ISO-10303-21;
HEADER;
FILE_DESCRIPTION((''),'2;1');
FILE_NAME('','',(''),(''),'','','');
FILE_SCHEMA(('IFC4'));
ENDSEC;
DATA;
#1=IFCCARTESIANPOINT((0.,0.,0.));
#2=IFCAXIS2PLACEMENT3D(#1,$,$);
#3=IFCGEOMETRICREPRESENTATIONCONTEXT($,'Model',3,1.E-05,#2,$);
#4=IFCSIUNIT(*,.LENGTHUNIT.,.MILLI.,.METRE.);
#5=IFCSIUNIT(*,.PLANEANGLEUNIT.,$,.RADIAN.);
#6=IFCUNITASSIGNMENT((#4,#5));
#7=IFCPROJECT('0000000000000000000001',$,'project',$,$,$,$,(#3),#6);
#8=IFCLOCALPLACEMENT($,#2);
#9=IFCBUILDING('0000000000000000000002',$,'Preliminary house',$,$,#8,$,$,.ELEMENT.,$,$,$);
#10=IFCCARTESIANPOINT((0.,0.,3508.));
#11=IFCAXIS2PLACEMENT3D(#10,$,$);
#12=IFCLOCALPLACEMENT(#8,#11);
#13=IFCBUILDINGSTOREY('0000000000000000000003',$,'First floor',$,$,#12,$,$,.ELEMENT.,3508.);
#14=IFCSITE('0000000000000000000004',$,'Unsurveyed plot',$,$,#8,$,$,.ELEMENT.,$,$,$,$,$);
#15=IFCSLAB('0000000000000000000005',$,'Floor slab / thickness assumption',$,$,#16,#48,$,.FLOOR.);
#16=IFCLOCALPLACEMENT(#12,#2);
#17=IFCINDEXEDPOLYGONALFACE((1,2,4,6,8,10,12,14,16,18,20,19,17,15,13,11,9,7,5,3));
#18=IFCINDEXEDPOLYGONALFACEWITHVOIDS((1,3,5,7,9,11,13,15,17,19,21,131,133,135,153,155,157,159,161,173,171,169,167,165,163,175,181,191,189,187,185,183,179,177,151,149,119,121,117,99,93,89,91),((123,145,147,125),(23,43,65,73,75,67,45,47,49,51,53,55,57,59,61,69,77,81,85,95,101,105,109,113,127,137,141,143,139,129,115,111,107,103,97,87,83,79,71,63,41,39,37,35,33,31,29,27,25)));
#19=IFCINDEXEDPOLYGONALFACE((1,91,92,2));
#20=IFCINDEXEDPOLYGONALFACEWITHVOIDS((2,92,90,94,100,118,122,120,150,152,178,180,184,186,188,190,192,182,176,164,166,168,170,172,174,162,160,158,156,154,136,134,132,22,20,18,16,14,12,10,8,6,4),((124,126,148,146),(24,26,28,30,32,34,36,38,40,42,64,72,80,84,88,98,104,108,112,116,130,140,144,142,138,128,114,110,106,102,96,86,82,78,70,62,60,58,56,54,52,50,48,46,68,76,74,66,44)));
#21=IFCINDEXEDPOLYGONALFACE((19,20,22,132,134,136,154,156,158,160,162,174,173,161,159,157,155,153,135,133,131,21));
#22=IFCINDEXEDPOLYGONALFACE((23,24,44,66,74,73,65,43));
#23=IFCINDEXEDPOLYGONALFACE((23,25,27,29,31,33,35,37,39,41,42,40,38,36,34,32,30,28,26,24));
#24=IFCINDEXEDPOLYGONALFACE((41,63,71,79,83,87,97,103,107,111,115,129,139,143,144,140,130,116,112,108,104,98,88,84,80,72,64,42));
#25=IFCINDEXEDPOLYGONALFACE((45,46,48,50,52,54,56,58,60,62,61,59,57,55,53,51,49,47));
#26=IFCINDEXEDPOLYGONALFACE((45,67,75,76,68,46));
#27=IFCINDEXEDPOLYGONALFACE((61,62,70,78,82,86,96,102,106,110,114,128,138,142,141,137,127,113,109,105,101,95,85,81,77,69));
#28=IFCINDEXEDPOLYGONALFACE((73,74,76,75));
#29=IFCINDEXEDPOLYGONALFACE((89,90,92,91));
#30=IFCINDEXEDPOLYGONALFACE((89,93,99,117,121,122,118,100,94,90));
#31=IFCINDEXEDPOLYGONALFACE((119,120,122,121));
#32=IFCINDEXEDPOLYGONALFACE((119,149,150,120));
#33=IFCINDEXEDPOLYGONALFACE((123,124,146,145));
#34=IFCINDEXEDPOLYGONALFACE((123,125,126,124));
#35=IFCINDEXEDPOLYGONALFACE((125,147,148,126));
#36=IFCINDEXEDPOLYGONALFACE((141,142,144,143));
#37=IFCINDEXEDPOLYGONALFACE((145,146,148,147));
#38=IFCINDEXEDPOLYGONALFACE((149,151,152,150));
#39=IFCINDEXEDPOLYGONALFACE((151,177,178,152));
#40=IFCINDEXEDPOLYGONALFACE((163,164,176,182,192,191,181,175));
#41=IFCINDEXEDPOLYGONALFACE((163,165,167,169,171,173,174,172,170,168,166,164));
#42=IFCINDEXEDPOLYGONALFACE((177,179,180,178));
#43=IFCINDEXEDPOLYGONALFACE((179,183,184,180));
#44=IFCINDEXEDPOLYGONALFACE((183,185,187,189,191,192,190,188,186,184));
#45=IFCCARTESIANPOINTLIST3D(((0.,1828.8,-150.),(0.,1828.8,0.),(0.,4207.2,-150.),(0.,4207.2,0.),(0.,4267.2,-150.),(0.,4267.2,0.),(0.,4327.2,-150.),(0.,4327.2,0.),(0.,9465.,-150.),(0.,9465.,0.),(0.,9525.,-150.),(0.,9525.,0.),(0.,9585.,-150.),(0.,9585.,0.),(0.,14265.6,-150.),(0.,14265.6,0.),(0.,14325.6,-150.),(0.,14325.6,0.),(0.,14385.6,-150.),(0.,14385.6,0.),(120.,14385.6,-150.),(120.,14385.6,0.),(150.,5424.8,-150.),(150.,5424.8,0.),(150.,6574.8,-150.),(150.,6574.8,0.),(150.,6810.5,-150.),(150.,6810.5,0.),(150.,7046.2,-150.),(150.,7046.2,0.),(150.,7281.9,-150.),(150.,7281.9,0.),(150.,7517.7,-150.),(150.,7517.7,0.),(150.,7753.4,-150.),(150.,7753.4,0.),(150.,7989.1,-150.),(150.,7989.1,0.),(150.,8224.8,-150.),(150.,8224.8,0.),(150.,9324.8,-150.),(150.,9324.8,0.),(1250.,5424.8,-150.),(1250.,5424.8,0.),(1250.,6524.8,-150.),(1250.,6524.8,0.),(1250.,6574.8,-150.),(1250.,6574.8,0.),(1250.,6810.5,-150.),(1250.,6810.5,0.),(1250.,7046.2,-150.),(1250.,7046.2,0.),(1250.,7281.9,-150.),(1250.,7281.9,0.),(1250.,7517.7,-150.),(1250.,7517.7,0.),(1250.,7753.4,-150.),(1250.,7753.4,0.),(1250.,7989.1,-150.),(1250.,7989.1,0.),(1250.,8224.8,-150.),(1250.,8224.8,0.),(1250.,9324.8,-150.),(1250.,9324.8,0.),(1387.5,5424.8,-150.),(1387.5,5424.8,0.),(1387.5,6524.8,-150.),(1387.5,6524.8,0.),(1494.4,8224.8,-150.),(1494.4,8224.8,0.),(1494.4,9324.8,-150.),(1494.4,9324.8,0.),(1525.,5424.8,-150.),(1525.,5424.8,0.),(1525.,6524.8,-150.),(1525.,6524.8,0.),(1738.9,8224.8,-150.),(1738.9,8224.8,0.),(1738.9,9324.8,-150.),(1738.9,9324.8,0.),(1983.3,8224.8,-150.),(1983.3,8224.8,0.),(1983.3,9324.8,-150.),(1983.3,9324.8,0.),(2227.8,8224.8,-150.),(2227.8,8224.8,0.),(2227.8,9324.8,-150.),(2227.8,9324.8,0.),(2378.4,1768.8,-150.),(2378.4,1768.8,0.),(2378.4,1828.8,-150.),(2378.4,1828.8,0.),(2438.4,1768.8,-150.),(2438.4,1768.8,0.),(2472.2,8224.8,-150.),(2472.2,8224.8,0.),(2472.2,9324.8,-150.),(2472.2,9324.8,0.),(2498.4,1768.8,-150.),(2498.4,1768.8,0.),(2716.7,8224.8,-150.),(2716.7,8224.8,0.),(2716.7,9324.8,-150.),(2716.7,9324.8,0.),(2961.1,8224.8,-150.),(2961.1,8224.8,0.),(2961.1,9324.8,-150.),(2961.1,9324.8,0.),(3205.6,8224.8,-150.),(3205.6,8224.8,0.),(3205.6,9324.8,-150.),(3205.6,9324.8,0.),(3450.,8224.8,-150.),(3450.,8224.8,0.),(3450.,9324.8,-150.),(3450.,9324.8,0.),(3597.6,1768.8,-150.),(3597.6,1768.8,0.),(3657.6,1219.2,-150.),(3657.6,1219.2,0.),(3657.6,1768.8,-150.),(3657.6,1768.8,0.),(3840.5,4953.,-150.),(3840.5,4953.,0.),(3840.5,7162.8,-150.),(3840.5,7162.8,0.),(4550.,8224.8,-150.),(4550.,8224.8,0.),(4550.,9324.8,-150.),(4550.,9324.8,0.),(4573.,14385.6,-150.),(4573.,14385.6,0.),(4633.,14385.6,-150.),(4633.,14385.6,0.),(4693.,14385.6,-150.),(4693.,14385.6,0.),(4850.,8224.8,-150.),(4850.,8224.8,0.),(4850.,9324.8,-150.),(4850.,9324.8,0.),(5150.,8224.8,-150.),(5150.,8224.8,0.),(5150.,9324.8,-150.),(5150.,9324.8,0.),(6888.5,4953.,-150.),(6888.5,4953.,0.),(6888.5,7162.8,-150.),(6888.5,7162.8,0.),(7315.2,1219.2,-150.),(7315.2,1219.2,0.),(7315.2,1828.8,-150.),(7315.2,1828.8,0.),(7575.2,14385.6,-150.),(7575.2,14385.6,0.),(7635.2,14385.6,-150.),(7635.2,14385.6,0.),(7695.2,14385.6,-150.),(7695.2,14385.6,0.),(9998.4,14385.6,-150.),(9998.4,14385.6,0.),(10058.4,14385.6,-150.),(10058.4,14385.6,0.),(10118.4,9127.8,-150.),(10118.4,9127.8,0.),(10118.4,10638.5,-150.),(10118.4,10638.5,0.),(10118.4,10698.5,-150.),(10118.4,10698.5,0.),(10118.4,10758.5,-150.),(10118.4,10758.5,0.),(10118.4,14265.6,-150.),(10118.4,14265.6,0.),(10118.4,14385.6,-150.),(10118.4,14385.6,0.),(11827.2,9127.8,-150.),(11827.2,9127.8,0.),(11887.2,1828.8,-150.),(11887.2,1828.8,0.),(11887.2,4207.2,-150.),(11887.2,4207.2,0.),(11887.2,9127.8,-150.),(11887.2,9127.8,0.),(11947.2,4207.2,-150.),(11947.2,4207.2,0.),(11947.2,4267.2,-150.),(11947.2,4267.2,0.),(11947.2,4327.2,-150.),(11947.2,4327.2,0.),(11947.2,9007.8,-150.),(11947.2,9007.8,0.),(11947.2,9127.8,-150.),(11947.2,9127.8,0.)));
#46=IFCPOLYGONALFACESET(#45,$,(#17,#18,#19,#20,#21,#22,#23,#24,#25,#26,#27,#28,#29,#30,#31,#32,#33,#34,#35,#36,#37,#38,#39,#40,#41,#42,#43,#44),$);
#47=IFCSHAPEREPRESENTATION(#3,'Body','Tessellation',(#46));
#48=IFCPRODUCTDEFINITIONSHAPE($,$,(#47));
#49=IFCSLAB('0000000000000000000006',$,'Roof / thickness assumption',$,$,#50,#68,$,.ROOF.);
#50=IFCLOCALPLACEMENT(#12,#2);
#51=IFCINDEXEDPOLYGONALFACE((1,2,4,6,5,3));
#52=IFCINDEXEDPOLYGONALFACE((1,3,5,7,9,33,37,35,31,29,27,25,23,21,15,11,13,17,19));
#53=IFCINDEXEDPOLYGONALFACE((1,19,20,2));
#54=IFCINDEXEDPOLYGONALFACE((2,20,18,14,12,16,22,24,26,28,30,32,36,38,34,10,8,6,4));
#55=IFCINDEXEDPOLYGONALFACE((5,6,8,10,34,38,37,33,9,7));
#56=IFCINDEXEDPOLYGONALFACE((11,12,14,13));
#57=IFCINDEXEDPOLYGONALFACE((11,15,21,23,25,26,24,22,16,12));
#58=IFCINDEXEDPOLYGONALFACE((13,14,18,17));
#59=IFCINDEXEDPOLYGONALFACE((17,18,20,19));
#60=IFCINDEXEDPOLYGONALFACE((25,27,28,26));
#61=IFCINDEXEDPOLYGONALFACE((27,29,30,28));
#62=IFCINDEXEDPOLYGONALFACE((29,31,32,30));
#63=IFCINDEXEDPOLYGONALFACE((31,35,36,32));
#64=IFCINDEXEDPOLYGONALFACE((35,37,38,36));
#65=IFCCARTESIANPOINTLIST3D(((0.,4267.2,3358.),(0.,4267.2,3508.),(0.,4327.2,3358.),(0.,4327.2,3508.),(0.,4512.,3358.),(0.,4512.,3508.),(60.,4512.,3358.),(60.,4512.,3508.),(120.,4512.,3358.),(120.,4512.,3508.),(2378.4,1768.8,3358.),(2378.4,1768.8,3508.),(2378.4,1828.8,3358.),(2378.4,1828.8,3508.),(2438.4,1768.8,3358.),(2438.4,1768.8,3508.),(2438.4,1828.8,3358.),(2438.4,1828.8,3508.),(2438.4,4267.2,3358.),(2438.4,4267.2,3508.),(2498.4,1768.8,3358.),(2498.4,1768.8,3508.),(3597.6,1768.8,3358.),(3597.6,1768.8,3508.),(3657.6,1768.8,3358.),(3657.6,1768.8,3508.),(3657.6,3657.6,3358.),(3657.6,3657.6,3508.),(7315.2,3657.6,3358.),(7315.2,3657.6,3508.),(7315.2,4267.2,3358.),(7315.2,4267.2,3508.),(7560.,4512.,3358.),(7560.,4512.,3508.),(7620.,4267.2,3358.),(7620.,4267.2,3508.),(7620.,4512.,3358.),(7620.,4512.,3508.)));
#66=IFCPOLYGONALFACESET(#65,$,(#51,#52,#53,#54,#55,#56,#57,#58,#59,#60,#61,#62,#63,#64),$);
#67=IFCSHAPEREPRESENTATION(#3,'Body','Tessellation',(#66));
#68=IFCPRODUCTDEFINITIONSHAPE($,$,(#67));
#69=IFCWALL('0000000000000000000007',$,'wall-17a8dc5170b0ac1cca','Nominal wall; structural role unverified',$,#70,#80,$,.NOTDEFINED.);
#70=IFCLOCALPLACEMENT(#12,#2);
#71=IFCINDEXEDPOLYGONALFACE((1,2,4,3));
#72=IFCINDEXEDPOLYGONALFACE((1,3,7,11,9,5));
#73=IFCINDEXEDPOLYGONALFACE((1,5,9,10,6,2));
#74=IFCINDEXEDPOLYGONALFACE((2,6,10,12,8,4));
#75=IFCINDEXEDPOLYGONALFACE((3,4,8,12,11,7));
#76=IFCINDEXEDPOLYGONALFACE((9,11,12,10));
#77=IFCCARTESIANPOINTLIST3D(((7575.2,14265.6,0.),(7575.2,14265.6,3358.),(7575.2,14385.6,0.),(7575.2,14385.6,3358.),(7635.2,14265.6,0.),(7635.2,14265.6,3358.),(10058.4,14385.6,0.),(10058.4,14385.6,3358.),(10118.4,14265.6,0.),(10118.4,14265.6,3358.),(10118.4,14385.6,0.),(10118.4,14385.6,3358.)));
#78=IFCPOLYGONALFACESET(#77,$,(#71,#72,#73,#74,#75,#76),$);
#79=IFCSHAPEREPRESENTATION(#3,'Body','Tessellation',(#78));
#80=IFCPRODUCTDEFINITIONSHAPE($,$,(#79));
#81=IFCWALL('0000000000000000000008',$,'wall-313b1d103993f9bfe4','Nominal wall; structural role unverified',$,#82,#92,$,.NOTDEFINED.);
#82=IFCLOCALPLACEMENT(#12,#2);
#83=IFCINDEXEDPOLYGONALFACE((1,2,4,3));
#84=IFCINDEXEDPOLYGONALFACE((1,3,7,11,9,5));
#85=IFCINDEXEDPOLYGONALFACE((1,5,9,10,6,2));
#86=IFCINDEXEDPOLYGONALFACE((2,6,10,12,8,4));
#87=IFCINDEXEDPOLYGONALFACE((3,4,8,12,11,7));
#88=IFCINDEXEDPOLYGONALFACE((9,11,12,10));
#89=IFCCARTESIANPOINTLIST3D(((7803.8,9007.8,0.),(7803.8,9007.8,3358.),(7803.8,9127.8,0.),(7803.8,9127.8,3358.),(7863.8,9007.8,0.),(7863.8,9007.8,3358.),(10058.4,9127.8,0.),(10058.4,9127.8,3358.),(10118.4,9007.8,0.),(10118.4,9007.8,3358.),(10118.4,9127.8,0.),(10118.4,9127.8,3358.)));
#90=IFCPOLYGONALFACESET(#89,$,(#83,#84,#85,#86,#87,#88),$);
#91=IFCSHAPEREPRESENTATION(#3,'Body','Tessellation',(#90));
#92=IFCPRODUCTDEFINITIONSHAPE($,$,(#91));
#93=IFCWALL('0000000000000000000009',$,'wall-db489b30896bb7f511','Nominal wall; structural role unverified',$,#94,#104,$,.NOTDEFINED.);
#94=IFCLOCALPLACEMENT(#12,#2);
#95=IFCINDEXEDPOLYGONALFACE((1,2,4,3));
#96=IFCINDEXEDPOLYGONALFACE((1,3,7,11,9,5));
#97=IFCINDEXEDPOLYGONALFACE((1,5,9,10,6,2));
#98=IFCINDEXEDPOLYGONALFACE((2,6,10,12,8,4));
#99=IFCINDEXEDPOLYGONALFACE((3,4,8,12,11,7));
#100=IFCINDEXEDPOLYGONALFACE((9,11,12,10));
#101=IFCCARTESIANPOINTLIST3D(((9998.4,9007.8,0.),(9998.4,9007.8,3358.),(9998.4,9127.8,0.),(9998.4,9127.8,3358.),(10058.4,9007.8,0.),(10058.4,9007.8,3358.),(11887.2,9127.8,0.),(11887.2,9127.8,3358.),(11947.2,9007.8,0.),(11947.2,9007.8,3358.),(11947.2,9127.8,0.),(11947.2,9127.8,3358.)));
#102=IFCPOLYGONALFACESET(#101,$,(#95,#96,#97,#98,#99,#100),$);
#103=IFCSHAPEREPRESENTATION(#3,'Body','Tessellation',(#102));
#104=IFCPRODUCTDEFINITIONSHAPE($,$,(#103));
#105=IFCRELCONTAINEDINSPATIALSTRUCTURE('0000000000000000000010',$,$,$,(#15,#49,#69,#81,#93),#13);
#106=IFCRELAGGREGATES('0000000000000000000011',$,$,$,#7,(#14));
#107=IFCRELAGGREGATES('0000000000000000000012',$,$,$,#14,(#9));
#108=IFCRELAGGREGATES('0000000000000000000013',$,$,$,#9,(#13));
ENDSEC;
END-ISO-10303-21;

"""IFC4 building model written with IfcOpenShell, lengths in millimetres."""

from ifc_helpers import new_model, si_unit, frame, origin, place, context, project, spatial, polyline, outline, extrude, element, save


model = new_model("IFC4")

# Units and contexts
model_context = context("Model", 3, precision=1e-05, world=origin())
ifc_project = project(units=[si_unit("LENGTHUNIT", "METRE", prefix="MILLI"), si_unit("PLANEANGLEUNIT", "RADIAN")], contexts=[model_context])

# Site, building, storey
placement_1 = place(None, origin())
site = spatial("IfcSite", under=ifc_project, at=placement_1, Name="Unsurveyed plot", CompositionType="ELEMENT")
building = spatial("IfcBuilding", under=site, at=placement_1, Name="Preliminary house", CompositionType="ELEMENT")
placement_2 = place(placement_1, frame((0.0, 0.0, 3508.0)))
storey = spatial("IfcBuildingStorey", under=building, at=placement_2, Name="First floor", CompositionType="ELEMENT", Elevation=3508.0)

# Slabs
element("IfcSlab", 1, at=placement_2, inside=storey, Name="Floor slab / thickness assumption", PredefinedType="FLOOR", context=model_context, shape_type="SweptSolid", body=[
    extrude(outline(polyline([(2378.4, 1828.8), (0.0, 1828.8), (0.0, 4207.2), (0.0, 4267.2), (0.0, 4327.2), (0.0, 9465.0), (0.0, 9525.0), (0.0, 9585.0), (0.0, 14265.6), (0.0, 14325.6), (0.0, 14385.6), (120.0, 14385.6), (4573.0, 14385.6), (4633.0, 14385.6), (4693.0, 14385.6), (7575.2, 14385.6), (7635.2, 14385.6), (7695.2, 14385.6), (9998.4, 14385.6), (10058.4, 14385.6), (10118.4, 14385.6), (10118.4, 14265.6), (10118.4, 10758.5), (10118.4, 10698.5), (10118.4, 10638.5), (10118.4, 9127.8), (11827.2, 9127.8), (11887.2, 9127.8), (11947.2, 9127.8), (11947.2, 9007.8), (11947.2, 4327.2), (11947.2, 4267.2), (11947.2, 4207.2), (11887.2, 4207.2), (11887.2, 1828.8), (7315.2, 1828.8), (7315.2, 1219.2), (3657.6, 1219.2), (3657.6, 1768.8), (3597.6, 1768.8), (2498.4, 1768.8), (2438.4, 1768.8), (2378.4, 1768.8), (2378.4, 1828.8)]), holes=[polyline([(1387.5, 6524.8), (1250.0, 6524.8), (1250.0, 6574.8), (1250.0, 6810.5), (1250.0, 7046.2), (1250.0, 7281.9), (1250.0, 7517.7), (1250.0, 7753.4), (1250.0, 7989.1), (1250.0, 8224.8), (1494.4, 8224.8), (1738.9, 8224.8), (1983.3, 8224.8), (2227.8, 8224.8), (2472.2, 8224.8), (2716.7, 8224.8), (2961.1, 8224.8), (3205.6, 8224.8), (3450.0, 8224.8), (4550.0, 8224.8), (4850.0, 8224.8), (5150.0, 8224.8), (5150.0, 9324.8), (4850.0, 9324.8), (4550.0, 9324.8), (3450.0, 9324.8), (3205.6, 9324.8), (2961.1, 9324.8), (2716.7, 9324.8), (2472.2, 9324.8), (2227.8, 9324.8), (1983.3, 9324.8), (1738.9, 9324.8), (1494.4, 9324.8), (1250.0, 9324.8), (150.0, 9324.8), (150.0, 8224.8), (150.0, 7989.1), (150.0, 7753.4), (150.0, 7517.7), (150.0, 7281.9), (150.0, 7046.2), (150.0, 6810.5), (150.0, 6574.8), (150.0, 5424.8), (1250.0, 5424.8), (1387.5, 5424.8), (1525.0, 5424.8), (1525.0, 6524.8), (1387.5, 6524.8)]), polyline([(6888.5, 7162.8), (3840.5, 7162.8), (3840.5, 4953.0), (6888.5, 4953.0), (6888.5, 7162.8)])]), frame((0.0, 0.0, -150.0)), (0.0, 0.0, 1.0), 150.0),
])
element("IfcSlab", 2, at=placement_2, inside=storey, Name="Roof / thickness assumption", PredefinedType="ROOF", context=model_context, shape_type="SweptSolid", body=[
    extrude(outline(polyline([(0.0, 4512.0), (60.0, 4512.0), (120.0, 4512.0), (7560.0, 4512.0), (7620.0, 4512.0), (7620.0, 4267.2), (7315.2, 4267.2), (7315.2, 3657.6), (3657.6, 3657.6), (3657.6, 1768.8), (3597.6, 1768.8), (2498.4, 1768.8), (2438.4, 1768.8), (2378.4, 1768.8), (2378.4, 1828.8), (2438.4, 1828.8), (2438.4, 4267.2), (0.0, 4267.2), (0.0, 4327.2), (0.0, 4512.0)])), frame((0.0, 0.0, 3358.0)), (0.0, 0.0, 1.0), 150.0),
])

# Wall
element("IfcWall", 3, at=placement_2, inside=storey, Name="wall-17a8dc5170b0ac1cca", Description="Nominal wall; structural role unverified", PredefinedType="NOTDEFINED", context=model_context, shape_type="SweptSolid", body=[
    extrude(outline(polyline([(10058.4, 14385.6), (10118.4, 14385.6), (10118.4, 14265.6), (7635.2, 14265.6), (7575.2, 14265.6), (7575.2, 14385.6), (10058.4, 14385.6)])), origin(), (0.0, 0.0, 1.0), 3358.0),
])

# Wall
element("IfcWall", 4, at=placement_2, inside=storey, Name="wall-313b1d103993f9bfe4", Description="Nominal wall; structural role unverified", PredefinedType="NOTDEFINED", context=model_context, shape_type="SweptSolid", body=[
    extrude(outline(polyline([(10058.4, 9127.8), (10118.4, 9127.8), (10118.4, 9007.8), (7863.8, 9007.8), (7803.8, 9007.8), (7803.8, 9127.8), (10058.4, 9127.8)])), origin(), (0.0, 0.0, 1.0), 3358.0),
])

# Wall
element("IfcWall", 5, at=placement_2, inside=storey, Name="wall-db489b30896bb7f511", Description="Nominal wall; structural role unverified", PredefinedType="NOTDEFINED", context=model_context, shape_type="SweptSolid", body=[
    extrude(outline(polyline([(11887.2, 9127.8), (11947.2, 9127.8), (11947.2, 9007.8), (10058.4, 9007.8), (9998.4, 9007.8), (9998.4, 9127.8), (11887.2, 9127.8)])), origin(), (0.0, 0.0, 1.0), 3358.0),
])

save(model, "model.ifc")
